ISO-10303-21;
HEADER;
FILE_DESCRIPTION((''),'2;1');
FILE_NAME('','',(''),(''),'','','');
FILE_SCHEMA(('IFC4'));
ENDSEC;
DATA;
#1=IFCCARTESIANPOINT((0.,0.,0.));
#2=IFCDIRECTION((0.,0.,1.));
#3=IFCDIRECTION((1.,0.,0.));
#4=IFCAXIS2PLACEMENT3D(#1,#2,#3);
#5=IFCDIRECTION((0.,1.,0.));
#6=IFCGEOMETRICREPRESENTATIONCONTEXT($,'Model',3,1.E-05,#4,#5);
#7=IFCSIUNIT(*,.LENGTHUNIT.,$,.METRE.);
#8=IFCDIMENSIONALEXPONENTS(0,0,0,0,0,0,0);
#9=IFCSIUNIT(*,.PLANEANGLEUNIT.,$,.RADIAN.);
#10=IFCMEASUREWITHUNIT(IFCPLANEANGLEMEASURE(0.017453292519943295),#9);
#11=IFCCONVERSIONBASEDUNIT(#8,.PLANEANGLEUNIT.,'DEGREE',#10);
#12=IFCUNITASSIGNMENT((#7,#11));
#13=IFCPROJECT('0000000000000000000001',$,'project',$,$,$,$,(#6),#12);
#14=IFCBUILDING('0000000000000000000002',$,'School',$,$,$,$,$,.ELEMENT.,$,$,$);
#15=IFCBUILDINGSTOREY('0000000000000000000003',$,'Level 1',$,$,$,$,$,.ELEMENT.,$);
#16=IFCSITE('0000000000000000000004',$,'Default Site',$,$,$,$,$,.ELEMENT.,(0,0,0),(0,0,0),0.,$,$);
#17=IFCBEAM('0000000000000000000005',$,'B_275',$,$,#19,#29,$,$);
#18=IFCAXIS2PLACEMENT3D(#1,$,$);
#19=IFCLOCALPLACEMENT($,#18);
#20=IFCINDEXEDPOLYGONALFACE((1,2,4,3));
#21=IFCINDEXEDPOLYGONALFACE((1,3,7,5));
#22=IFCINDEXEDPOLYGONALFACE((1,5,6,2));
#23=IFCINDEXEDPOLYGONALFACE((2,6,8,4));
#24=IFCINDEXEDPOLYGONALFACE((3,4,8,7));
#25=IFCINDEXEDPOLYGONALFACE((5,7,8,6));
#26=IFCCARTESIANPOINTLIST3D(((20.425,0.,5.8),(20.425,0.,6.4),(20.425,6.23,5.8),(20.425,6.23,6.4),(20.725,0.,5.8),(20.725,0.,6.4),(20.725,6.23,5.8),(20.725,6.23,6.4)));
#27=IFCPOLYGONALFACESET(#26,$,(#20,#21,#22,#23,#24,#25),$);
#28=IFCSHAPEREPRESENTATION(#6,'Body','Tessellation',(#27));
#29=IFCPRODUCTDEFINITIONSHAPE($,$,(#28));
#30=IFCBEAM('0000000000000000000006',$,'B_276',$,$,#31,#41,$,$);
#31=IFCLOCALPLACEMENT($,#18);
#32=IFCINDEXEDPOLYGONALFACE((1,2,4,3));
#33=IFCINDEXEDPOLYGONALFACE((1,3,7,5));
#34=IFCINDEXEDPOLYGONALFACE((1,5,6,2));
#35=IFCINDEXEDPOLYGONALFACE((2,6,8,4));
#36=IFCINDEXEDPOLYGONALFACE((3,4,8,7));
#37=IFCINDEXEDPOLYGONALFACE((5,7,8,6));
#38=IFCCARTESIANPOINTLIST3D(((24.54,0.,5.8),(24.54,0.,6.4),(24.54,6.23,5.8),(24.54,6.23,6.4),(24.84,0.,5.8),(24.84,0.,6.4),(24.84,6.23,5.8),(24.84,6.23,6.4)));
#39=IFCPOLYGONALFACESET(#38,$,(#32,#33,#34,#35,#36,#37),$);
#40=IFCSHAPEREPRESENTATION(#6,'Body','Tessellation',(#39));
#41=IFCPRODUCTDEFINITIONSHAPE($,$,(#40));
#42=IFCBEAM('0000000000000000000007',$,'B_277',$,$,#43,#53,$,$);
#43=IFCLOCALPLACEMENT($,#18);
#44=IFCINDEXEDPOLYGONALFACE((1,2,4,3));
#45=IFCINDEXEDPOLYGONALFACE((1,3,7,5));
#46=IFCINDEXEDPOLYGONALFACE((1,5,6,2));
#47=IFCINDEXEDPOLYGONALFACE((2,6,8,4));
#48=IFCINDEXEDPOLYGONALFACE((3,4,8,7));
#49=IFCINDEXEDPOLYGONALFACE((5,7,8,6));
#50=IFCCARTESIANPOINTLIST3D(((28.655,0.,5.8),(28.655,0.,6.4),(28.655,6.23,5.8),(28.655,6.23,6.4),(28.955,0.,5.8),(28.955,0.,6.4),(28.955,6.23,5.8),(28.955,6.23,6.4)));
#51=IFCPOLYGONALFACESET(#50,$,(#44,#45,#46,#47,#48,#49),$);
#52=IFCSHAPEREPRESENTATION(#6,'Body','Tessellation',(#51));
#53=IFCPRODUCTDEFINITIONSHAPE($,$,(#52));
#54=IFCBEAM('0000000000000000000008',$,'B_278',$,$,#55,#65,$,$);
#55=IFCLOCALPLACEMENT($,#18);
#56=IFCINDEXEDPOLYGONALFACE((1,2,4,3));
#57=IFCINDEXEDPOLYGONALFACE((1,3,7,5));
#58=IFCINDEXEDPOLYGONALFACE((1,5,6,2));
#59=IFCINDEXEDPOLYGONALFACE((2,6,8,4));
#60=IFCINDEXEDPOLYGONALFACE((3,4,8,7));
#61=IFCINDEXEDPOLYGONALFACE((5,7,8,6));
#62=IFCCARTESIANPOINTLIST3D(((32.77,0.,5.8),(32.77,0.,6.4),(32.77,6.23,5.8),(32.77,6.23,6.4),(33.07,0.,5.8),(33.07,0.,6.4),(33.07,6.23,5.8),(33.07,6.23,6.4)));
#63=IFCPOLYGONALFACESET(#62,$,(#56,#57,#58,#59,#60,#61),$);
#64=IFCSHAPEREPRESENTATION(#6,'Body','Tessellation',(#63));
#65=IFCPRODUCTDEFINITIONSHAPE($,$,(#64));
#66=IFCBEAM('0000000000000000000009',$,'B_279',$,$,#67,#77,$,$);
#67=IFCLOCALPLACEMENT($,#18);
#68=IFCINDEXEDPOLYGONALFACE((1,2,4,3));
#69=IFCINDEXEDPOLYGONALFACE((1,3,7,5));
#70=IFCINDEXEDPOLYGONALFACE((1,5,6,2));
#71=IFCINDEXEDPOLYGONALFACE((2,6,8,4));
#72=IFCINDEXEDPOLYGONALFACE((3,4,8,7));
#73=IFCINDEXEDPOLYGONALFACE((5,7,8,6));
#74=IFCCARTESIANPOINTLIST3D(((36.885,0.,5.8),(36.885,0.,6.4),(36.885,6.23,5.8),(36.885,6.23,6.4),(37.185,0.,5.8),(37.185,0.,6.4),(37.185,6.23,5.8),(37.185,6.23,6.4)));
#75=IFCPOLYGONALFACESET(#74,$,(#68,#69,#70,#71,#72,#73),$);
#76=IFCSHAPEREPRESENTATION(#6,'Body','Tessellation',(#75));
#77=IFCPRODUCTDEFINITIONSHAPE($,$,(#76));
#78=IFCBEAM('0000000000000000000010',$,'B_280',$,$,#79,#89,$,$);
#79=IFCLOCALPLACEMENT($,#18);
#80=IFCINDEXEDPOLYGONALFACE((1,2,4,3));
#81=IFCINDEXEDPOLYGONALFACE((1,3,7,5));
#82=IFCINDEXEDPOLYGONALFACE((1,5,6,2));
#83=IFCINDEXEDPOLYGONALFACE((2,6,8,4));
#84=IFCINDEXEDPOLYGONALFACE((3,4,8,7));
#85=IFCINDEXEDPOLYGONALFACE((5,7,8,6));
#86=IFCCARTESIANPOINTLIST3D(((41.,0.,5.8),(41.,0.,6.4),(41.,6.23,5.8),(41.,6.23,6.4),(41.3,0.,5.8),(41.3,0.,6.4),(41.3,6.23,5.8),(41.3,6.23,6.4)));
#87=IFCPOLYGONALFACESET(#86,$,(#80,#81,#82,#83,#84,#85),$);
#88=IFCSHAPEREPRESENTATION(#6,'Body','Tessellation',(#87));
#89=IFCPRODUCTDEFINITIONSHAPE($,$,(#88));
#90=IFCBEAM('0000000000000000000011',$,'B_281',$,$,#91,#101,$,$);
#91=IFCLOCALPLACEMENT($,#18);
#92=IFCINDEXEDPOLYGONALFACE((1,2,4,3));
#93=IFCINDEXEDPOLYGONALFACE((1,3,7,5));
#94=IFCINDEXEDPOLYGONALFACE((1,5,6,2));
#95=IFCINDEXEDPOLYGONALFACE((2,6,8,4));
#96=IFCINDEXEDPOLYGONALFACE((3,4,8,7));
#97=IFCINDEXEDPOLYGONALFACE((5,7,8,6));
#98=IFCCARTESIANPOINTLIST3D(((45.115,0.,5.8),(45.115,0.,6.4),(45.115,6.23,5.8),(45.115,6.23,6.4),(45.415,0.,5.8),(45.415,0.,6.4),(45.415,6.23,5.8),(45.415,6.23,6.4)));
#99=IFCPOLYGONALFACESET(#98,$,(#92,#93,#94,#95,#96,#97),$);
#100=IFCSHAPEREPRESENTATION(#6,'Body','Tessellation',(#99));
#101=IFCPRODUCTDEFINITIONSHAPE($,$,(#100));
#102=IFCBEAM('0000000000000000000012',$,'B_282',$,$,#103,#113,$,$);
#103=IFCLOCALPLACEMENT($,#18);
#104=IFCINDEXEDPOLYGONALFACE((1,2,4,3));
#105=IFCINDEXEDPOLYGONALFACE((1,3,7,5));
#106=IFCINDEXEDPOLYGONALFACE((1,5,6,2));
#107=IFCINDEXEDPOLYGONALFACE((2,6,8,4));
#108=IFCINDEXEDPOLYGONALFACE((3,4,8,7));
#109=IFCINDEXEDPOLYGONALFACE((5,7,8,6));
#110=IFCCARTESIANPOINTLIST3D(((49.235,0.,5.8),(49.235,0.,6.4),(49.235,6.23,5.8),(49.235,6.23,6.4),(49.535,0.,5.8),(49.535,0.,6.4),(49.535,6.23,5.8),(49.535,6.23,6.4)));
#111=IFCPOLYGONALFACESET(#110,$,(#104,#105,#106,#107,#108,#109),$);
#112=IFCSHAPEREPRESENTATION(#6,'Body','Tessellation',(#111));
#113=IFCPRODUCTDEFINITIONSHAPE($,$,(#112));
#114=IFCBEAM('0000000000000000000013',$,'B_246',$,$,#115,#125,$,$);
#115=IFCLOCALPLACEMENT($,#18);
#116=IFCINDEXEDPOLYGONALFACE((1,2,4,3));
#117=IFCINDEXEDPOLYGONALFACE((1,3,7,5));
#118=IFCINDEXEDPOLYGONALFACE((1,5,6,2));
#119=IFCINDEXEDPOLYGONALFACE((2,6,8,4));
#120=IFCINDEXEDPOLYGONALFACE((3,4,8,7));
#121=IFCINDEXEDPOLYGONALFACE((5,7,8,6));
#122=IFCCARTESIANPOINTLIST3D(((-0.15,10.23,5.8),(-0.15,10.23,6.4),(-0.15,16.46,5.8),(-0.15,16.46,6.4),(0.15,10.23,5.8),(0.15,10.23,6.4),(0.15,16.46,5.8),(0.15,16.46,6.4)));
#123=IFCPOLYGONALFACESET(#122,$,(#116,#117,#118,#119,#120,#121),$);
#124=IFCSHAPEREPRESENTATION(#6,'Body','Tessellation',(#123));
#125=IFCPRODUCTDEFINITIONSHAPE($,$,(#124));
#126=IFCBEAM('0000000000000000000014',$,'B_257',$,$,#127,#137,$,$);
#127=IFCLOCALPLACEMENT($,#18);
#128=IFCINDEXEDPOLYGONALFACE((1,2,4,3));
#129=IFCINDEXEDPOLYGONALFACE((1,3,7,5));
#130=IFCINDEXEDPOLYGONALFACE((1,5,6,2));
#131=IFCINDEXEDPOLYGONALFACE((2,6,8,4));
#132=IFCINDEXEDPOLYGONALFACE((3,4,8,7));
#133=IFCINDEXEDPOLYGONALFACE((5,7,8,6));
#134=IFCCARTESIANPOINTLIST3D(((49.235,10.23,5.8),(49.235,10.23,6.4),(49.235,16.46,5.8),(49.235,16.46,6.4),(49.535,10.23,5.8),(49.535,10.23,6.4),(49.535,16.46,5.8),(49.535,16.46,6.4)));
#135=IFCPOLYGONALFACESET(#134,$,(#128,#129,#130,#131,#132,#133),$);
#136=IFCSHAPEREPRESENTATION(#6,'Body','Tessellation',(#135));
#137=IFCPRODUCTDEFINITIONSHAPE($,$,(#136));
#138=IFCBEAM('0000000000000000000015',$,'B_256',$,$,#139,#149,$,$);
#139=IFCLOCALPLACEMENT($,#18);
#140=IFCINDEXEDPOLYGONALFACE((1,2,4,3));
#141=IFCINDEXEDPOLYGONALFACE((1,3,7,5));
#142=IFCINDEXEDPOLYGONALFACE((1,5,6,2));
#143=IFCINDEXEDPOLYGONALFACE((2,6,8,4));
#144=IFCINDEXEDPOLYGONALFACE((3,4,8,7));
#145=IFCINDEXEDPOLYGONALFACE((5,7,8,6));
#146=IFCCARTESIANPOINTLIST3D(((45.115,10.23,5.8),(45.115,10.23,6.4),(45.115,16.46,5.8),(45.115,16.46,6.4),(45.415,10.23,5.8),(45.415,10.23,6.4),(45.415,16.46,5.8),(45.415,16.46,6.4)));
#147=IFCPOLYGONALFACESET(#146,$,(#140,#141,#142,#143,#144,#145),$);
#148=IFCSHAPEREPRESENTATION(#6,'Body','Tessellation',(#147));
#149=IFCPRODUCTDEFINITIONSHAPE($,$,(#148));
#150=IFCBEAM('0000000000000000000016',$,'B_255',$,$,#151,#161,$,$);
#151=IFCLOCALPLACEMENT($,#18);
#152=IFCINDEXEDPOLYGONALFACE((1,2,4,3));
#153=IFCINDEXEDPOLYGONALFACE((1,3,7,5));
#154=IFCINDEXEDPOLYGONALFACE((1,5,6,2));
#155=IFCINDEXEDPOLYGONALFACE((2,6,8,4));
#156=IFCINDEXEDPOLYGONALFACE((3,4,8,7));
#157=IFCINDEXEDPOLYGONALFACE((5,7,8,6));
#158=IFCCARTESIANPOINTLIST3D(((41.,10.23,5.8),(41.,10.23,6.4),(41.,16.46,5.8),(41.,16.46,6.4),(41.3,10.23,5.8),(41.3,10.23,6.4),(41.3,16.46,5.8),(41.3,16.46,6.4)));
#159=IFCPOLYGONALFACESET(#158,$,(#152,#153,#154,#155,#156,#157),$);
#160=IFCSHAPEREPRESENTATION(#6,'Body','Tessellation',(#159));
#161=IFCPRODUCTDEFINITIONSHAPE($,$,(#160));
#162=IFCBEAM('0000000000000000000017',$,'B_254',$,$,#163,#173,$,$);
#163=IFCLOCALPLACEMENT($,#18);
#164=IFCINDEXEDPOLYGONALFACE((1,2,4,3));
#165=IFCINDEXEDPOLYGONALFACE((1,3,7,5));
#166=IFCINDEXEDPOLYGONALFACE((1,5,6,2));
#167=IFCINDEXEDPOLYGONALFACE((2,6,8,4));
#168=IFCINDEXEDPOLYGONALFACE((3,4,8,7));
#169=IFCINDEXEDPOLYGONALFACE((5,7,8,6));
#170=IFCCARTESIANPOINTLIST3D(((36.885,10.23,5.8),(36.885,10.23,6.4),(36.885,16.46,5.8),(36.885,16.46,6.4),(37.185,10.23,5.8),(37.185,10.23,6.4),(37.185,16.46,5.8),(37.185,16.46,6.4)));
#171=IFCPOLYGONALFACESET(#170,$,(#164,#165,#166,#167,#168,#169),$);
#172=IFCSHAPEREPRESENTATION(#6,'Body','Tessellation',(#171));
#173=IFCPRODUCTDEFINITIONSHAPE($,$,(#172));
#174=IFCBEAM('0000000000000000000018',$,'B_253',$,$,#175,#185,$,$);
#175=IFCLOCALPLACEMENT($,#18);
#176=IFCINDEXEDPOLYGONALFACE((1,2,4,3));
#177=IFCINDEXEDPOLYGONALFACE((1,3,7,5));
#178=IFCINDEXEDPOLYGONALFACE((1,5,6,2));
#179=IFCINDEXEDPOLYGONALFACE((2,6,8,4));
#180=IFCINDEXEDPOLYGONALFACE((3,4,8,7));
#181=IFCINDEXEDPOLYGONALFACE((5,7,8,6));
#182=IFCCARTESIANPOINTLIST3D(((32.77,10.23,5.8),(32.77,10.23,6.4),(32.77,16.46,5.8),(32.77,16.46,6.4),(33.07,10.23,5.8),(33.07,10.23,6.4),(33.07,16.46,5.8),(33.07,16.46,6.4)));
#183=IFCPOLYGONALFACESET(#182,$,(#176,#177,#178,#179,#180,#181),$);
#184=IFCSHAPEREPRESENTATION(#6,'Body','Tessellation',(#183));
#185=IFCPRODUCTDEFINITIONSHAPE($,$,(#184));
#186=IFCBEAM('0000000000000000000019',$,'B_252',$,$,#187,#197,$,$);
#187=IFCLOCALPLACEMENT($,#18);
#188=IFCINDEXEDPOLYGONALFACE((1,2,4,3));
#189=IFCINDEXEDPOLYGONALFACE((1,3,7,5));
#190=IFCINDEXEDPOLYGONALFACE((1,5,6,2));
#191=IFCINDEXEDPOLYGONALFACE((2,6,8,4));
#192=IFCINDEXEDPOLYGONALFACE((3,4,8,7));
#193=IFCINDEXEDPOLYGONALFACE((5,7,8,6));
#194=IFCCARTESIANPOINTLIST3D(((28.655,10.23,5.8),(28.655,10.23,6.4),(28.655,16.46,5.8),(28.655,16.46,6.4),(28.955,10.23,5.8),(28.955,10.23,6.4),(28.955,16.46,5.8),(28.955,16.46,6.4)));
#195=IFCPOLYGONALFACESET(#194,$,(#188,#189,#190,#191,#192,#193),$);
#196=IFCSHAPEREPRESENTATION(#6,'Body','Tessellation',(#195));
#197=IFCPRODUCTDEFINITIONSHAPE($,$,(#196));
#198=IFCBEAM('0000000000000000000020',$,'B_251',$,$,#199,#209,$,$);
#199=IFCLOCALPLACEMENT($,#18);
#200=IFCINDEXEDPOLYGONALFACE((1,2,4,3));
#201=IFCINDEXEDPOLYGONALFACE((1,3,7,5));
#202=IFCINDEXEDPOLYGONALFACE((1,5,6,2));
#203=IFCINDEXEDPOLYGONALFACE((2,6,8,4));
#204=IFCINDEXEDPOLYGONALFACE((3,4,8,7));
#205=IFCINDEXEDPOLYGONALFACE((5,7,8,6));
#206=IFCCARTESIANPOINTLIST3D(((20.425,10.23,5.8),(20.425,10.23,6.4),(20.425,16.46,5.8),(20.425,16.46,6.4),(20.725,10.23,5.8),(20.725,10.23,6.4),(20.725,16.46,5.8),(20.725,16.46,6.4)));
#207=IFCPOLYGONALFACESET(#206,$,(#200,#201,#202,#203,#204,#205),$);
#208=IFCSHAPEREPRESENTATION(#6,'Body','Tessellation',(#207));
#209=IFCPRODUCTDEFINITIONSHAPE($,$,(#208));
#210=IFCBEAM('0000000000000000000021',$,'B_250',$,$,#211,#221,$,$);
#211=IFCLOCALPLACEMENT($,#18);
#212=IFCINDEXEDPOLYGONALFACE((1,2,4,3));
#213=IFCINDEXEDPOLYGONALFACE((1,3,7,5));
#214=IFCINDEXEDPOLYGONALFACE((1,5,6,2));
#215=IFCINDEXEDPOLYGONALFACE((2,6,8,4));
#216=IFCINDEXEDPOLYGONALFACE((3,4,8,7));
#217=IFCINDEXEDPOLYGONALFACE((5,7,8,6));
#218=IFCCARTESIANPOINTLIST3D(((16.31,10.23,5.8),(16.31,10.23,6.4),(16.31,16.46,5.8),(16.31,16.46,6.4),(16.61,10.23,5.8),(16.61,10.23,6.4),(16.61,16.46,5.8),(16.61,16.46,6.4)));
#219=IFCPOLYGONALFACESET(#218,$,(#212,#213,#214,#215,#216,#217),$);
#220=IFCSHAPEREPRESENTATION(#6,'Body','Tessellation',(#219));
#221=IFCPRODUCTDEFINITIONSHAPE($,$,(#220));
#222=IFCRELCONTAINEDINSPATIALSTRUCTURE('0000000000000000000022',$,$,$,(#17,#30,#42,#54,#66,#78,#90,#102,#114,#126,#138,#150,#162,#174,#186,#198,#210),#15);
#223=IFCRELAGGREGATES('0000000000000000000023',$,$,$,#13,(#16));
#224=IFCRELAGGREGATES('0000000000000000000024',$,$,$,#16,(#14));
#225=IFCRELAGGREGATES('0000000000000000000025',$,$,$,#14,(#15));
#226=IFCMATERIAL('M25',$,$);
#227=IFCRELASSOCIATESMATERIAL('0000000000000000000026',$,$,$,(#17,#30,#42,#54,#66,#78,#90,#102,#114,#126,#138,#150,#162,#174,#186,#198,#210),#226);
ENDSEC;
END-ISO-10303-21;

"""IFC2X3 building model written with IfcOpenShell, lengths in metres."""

from ifc_helpers import new_model, entity, si_unit, converted_unit, direction, frame, frame_2d, origin_with_axes, place, context, project, spatial, rectangle, extrude, material, element, save


model = new_model("IFC2X3")

# Units and contexts
model_context = context("Model", 3, precision=1e-05, world=origin_with_axes(), true_north=direction((0.0, 1.0, 0.0)))
ifc_project = project(units=[si_unit("LENGTHUNIT", "METRE"), converted_unit("PLANEANGLEUNIT", "DEGREE", entity("IfcPlaneAngleMeasure", 0.017453292519943295), si_unit("PLANEANGLEUNIT", "RADIAN"), dimensions=[0, 0, 0, 0, 0, 0, 0])], contexts=[model_context])

# Site, building, storey
site = spatial("IfcSite", under=ifc_project, Name="Default Site", CompositionType="ELEMENT", RefLatitude=(0, 0, 0), RefLongitude=(0, 0, 0), RefElevation=0.0)
building = spatial("IfcBuilding", under=site, Name="School", CompositionType="ELEMENT")
storey = spatial("IfcBuildingStorey", under=building, Name="Level 1", CompositionType="ELEMENT")

# Beams
ifc_material = material(Name="M25")
placement = place(None, origin_with_axes())
element("IfcBeam", 1, at=placement, inside=storey, material=ifc_material, Name="B_275", context=model_context, shape_type="SweptSolid", body=[
    extrude(rectangle(XDim=0.3, YDim=0.6, at=frame_2d((0.0, 0.0), x_axis=(0.0, 1.0, 0.0))), frame((20.575, 0.0, 6.1), z_axis=(0.0, 1.0, 0.0), x_axis=(0.0, 0.0, -1.0)), (0.0, 0.0, 1.0), 6.23),
])
element("IfcBeam", 2, at=placement, inside=storey, material=ifc_material, Name="B_276", context=model_context, shape_type="SweptSolid", body=[
    extrude(rectangle(XDim=0.3, YDim=0.6, at=frame_2d((0.0, 0.0), x_axis=(0.0, 1.0, 0.0))), frame((24.69, 0.0, 6.1), z_axis=(0.0, 1.0, 0.0), x_axis=(0.0, 0.0, -1.0)), (0.0, 0.0, 1.0), 6.23),
])
element("IfcBeam", 3, at=placement, inside=storey, material=ifc_material, Name="B_277", context=model_context, shape_type="SweptSolid", body=[
    extrude(rectangle(XDim=0.3, YDim=0.6, at=frame_2d((0.0, 0.0), x_axis=(0.0, 1.0, 0.0))), frame((28.805, 0.0, 6.1), z_axis=(0.0, 1.0, 0.0), x_axis=(0.0, 0.0, -1.0)), (0.0, 0.0, 1.0), 6.23),
])
element("IfcBeam", 4, at=placement, inside=storey, material=ifc_material, Name="B_278", context=model_context, shape_type="SweptSolid", body=[
    extrude(rectangle(XDim=0.3, YDim=0.6, at=frame_2d((0.0, 0.0), x_axis=(0.0, 1.0, 0.0))), frame((32.92, 0.0, 6.1), z_axis=(0.0, 1.0, 0.0), x_axis=(0.0, 0.0, -1.0)), (0.0, 0.0, 1.0), 6.23),
])
element("IfcBeam", 5, at=placement, inside=storey, material=ifc_material, Name="B_279", context=model_context, shape_type="SweptSolid", body=[
    extrude(rectangle(XDim=0.3, YDim=0.6, at=frame_2d((0.0, 0.0), x_axis=(0.0, 1.0, 0.0))), frame((37.035, 0.0, 6.1), z_axis=(0.0, 1.0, 0.0), x_axis=(0.0, 0.0, -1.0)), (0.0, 0.0, 1.0), 6.23),
])
element("IfcBeam", 6, at=placement, inside=storey, material=ifc_material, Name="B_280", context=model_context, shape_type="SweptSolid", body=[
    extrude(rectangle(XDim=0.3, YDim=0.6, at=frame_2d((0.0, 0.0), x_axis=(0.0, 1.0, 0.0))), frame((41.15, 0.0, 6.1), z_axis=(0.0, 1.0, 0.0), x_axis=(0.0, 0.0, -1.0)), (0.0, 0.0, 1.0), 6.23),
])
element("IfcBeam", 7, at=placement, inside=storey, material=ifc_material, Name="B_281", context=model_context, shape_type="SweptSolid", body=[
    extrude(rectangle(XDim=0.3, YDim=0.6, at=frame_2d((0.0, 0.0), x_axis=(0.0, 1.0, 0.0))), frame((45.265, 0.0, 6.1), z_axis=(0.0, 1.0, 0.0), x_axis=(0.0, 0.0, -1.0)), (0.0, 0.0, 1.0), 6.23),
])
element("IfcBeam", 8, at=placement, inside=storey, material=ifc_material, Name="B_282", context=model_context, shape_type="SweptSolid", body=[
    extrude(rectangle(XDim=0.3, YDim=0.6, at=frame_2d((0.0, 0.0), x_axis=(0.0, 1.0, 0.0))), frame((49.385, 0.0, 6.1), z_axis=(0.0, 1.0, 0.0), x_axis=(0.0, 0.0, -1.0)), (0.0, 0.0, 1.0), 6.23),
])
element("IfcBeam", 9, at=placement, inside=storey, material=ifc_material, Name="B_246", context=model_context, shape_type="SweptSolid", body=[
    extrude(rectangle(XDim=0.3, YDim=0.6, at=frame_2d((0.0, 0.0), x_axis=(0.0, 1.0, 0.0))), frame((0.0, 10.23, 6.1), z_axis=(0.0, 1.0, 0.0), x_axis=(0.0, 0.0, -1.0)), (0.0, 0.0, 1.0), 6.23),
])
element("IfcBeam", 10, at=placement, inside=storey, material=ifc_material, Name="B_257", context=model_context, shape_type="SweptSolid", body=[
    extrude(rectangle(XDim=0.3, YDim=0.6, at=frame_2d((0.0, 0.0), x_axis=(0.0, 1.0, 0.0))), frame((49.385, 10.23, 6.1), z_axis=(0.0, 1.0, 0.0), x_axis=(0.0, 0.0, -1.0)), (0.0, 0.0, 1.0), 6.23),
])
element("IfcBeam", 11, at=placement, inside=storey, material=ifc_material, Name="B_256", context=model_context, shape_type="SweptSolid", body=[
    extrude(rectangle(XDim=0.3, YDim=0.6, at=frame_2d((0.0, 0.0), x_axis=(0.0, 1.0, 0.0))), frame((45.265, 10.23, 6.1), z_axis=(0.0, 1.0, 0.0), x_axis=(0.0, 0.0, -1.0)), (0.0, 0.0, 1.0), 6.23),
])
element("IfcBeam", 12, at=placement, inside=storey, material=ifc_material, Name="B_255", context=model_context, shape_type="SweptSolid", body=[
    extrude(rectangle(XDim=0.3, YDim=0.6, at=frame_2d((0.0, 0.0), x_axis=(0.0, 1.0, 0.0))), frame((41.15, 10.23, 6.1), z_axis=(0.0, 1.0, 0.0), x_axis=(0.0, 0.0, -1.0)), (0.0, 0.0, 1.0), 6.23),
])
element("IfcBeam", 13, at=placement, inside=storey, material=ifc_material, Name="B_254", context=model_context, shape_type="SweptSolid", body=[
    extrude(rectangle(XDim=0.3, YDim=0.6, at=frame_2d((0.0, 0.0), x_axis=(0.0, 1.0, 0.0))), frame((37.035, 10.23, 6.1), z_axis=(0.0, 1.0, 0.0), x_axis=(0.0, 0.0, -1.0)), (0.0, 0.0, 1.0), 6.23),
])
element("IfcBeam", 14, at=placement, inside=storey, material=ifc_material, Name="B_253", context=model_context, shape_type="SweptSolid", body=[
    extrude(rectangle(XDim=0.3, YDim=0.6, at=frame_2d((0.0, 0.0), x_axis=(0.0, 1.0, 0.0))), frame((32.92, 10.23, 6.1), z_axis=(0.0, 1.0, 0.0), x_axis=(0.0, 0.0, -1.0)), (0.0, 0.0, 1.0), 6.23),
])
element("IfcBeam", 15, at=placement, inside=storey, material=ifc_material, Name="B_252", context=model_context, shape_type="SweptSolid", body=[
    extrude(rectangle(XDim=0.3, YDim=0.6, at=frame_2d((0.0, 0.0), x_axis=(0.0, 1.0, 0.0))), frame((28.805, 10.23, 6.1), z_axis=(0.0, 1.0, 0.0), x_axis=(0.0, 0.0, -1.0)), (0.0, 0.0, 1.0), 6.23),
])
element("IfcBeam", 16, at=placement, inside=storey, material=ifc_material, Name="B_251", context=model_context, shape_type="SweptSolid", body=[
    extrude(rectangle(XDim=0.3, YDim=0.6, at=frame_2d((0.0, 0.0), x_axis=(0.0, 1.0, 0.0))), frame((20.575, 10.23, 6.1), z_axis=(0.0, 1.0, 0.0), x_axis=(0.0, 0.0, -1.0)), (0.0, 0.0, 1.0), 6.23),
])
element("IfcBeam", 17, at=placement, inside=storey, material=ifc_material, Name="B_250", context=model_context, shape_type="SweptSolid", body=[
    extrude(rectangle(XDim=0.3, YDim=0.6, at=frame_2d((0.0, 0.0), x_axis=(0.0, 1.0, 0.0))), frame((16.46, 10.23, 6.1), z_axis=(0.0, 1.0, 0.0), x_axis=(0.0, 0.0, -1.0)), (0.0, 0.0, 1.0), 6.23),
])

save(model, "model.ifc")
